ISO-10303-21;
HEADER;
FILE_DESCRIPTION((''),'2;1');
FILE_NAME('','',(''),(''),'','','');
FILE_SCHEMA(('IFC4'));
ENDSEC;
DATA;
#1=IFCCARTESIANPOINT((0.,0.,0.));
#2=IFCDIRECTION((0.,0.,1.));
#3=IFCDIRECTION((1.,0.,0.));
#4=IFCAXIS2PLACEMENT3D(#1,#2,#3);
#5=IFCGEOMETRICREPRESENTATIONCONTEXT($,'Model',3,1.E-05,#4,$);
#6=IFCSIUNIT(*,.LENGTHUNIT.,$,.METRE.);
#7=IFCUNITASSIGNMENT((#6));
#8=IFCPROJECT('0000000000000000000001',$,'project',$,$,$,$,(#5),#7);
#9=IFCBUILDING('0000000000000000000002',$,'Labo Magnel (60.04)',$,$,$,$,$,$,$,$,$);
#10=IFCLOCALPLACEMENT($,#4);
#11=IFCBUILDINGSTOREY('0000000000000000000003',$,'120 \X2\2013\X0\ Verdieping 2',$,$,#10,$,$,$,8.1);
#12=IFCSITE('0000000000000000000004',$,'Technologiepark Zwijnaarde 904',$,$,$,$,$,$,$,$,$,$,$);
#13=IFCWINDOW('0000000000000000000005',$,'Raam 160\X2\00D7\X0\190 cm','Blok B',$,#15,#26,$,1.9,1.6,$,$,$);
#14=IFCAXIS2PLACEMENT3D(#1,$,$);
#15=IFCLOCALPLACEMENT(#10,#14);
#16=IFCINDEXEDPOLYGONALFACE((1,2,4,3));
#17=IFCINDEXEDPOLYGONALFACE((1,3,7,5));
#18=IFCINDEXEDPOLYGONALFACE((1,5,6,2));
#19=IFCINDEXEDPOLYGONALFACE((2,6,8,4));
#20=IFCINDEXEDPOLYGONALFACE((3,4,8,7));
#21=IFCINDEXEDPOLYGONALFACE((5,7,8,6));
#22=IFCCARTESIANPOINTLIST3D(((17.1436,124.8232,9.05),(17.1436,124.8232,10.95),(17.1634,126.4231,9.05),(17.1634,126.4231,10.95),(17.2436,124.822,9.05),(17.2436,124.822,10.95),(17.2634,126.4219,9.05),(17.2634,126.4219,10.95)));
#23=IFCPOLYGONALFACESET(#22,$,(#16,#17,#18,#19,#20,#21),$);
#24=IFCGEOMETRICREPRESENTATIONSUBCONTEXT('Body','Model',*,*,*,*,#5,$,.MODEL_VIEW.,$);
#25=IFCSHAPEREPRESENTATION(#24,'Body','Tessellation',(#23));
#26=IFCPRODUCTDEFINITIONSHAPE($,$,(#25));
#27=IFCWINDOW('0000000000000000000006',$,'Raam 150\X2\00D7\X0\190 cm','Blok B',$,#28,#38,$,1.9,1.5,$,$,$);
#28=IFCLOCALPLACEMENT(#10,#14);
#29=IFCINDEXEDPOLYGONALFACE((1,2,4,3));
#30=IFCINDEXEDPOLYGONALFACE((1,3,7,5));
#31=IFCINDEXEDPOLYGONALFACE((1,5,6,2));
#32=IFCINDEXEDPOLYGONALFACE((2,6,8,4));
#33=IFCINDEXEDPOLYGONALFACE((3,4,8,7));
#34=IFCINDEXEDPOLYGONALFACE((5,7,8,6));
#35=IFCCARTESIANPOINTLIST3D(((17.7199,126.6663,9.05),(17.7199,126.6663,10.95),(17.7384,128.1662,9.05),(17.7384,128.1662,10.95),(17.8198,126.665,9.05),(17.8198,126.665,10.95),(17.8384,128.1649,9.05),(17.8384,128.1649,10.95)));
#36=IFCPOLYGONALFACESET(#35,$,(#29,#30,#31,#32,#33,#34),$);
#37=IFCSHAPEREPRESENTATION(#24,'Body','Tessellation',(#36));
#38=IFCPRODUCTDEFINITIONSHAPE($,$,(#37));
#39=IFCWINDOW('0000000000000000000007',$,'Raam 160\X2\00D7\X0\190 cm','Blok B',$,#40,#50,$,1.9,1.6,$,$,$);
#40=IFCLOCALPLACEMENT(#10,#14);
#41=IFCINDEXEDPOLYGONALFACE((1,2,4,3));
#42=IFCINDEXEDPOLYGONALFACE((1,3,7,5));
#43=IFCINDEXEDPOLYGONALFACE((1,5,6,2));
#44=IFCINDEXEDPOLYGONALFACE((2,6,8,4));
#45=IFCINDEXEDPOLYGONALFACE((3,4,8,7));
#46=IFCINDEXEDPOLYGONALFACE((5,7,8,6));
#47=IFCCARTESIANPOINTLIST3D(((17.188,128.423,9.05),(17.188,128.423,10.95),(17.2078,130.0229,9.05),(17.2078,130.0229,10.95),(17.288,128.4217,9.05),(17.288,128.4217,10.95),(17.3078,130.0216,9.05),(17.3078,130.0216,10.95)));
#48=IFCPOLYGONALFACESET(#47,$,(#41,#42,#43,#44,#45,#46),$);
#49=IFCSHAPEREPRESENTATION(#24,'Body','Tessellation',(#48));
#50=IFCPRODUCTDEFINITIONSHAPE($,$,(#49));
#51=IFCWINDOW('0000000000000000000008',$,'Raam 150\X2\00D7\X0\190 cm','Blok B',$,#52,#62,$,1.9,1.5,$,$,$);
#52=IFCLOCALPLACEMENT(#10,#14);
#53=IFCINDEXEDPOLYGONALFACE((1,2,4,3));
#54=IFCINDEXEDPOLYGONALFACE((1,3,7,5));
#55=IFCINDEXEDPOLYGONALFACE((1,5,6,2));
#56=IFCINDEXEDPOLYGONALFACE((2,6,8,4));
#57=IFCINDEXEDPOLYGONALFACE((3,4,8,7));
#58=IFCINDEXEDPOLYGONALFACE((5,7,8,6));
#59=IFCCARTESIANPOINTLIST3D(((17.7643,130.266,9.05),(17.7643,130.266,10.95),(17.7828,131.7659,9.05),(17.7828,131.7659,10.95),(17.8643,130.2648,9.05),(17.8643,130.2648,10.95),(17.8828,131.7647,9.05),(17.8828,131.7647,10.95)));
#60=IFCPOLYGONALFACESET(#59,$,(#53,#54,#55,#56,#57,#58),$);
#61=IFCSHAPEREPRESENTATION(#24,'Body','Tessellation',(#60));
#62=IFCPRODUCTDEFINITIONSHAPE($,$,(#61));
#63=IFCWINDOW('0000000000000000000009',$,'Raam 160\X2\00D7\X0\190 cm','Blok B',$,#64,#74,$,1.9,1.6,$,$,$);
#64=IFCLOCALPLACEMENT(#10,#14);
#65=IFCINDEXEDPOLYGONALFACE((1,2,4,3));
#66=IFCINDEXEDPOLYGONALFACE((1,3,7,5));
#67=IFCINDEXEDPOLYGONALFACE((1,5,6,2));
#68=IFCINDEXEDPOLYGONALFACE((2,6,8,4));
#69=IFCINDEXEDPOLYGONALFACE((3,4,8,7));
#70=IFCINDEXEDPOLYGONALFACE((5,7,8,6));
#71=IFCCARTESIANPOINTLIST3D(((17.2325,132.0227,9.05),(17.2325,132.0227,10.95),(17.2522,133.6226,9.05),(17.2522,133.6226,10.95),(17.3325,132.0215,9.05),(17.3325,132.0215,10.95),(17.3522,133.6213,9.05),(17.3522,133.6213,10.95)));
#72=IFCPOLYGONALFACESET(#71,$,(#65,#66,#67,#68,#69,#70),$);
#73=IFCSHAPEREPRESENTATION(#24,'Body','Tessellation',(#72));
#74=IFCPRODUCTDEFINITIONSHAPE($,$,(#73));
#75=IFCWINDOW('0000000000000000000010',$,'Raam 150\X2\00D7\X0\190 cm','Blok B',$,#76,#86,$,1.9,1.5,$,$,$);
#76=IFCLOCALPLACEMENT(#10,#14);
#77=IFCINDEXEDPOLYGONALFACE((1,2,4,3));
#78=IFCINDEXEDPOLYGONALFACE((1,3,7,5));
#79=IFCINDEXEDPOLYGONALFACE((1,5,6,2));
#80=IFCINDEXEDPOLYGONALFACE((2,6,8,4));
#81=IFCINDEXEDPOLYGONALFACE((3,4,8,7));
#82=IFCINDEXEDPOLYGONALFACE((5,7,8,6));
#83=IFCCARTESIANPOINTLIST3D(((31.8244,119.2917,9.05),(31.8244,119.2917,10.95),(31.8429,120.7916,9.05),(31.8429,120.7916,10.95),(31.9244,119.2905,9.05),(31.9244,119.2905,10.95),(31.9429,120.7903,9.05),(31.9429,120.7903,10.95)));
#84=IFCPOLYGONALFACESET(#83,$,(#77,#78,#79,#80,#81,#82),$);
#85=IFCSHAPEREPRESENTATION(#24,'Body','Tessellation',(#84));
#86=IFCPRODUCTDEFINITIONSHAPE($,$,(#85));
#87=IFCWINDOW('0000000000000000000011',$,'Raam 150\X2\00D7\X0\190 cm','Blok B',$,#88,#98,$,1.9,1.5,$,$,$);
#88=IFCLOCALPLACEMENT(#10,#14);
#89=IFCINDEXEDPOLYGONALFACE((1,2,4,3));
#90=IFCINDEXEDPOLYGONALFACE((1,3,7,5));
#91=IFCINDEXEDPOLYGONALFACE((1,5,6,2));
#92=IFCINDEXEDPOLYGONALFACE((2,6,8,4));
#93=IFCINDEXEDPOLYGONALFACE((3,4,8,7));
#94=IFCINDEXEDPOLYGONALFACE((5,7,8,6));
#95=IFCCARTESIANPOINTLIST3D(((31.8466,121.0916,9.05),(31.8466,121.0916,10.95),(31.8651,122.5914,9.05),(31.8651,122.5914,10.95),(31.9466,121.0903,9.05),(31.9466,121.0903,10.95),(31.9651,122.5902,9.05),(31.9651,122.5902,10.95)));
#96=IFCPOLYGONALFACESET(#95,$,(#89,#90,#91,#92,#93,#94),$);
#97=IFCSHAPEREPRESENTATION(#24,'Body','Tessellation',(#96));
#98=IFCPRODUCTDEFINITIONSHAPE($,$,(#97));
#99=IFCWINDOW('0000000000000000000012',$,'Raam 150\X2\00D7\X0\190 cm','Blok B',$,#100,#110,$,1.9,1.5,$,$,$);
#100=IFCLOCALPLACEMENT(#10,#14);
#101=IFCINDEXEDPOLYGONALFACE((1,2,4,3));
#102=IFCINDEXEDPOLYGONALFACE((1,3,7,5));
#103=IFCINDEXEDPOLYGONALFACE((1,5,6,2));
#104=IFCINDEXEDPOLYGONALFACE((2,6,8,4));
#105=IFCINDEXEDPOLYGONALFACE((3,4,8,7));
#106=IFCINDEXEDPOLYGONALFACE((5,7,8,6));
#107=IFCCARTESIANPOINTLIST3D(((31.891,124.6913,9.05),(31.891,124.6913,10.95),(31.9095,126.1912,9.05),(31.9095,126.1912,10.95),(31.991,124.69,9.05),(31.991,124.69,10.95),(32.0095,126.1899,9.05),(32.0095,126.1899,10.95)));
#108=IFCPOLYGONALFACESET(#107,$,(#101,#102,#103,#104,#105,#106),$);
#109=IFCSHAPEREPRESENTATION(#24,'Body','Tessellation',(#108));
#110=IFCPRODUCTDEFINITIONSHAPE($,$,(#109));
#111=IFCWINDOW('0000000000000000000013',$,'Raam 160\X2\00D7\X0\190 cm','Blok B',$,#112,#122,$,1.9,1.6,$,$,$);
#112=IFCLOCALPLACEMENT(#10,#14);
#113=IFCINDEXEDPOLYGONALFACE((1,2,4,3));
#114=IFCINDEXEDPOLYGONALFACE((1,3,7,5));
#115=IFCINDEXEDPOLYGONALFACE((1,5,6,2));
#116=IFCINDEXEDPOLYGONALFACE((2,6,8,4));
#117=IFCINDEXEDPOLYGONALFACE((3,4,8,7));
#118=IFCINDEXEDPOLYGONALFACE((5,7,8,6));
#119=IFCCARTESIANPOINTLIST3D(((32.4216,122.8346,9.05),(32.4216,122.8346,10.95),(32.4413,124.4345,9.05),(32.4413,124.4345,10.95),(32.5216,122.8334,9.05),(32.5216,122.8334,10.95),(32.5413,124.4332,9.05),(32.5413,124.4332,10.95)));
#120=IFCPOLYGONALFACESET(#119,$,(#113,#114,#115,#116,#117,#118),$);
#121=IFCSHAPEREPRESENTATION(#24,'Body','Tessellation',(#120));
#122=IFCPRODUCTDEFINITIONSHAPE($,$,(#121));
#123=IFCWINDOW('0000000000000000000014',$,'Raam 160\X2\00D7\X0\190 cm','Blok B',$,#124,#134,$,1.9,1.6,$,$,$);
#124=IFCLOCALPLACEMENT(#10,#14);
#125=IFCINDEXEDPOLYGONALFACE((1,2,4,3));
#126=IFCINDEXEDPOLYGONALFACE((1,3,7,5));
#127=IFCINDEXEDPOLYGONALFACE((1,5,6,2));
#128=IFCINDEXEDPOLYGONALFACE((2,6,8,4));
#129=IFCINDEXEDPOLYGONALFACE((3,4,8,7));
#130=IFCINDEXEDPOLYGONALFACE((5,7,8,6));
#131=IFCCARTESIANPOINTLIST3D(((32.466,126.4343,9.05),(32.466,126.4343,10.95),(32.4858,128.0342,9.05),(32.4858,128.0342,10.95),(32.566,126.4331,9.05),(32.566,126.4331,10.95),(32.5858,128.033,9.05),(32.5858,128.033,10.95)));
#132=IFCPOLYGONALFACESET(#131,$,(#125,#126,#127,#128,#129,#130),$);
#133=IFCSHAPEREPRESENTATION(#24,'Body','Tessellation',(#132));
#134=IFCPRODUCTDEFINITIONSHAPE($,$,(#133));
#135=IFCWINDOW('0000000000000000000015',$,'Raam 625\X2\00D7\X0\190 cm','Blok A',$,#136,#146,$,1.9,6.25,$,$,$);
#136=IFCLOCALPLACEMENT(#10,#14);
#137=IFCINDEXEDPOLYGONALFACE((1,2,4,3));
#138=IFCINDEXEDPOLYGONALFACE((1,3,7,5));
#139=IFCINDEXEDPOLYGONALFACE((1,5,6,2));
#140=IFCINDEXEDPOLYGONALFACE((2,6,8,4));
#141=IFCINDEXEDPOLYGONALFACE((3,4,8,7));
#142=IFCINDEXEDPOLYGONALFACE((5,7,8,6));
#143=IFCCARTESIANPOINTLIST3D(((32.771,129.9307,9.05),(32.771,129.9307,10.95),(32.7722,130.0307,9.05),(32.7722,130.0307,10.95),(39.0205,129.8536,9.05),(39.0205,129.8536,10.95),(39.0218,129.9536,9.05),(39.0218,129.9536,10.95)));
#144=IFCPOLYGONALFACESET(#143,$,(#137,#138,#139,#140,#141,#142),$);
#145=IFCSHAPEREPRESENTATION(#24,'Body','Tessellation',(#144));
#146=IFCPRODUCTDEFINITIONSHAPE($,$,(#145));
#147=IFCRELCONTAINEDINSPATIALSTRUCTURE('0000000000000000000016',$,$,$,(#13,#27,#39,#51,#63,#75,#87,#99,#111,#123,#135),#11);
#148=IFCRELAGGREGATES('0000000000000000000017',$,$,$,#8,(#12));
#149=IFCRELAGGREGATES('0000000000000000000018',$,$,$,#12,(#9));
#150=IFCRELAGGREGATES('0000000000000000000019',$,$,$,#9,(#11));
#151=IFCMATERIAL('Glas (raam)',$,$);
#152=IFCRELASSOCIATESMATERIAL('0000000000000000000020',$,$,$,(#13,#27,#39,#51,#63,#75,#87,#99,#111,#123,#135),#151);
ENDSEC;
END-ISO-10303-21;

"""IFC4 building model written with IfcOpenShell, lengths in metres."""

from ifc_helpers import new_model, si_unit, frame, origin, origin_with_axes, place, context, subcontext, project, spatial, polyline, outline, extrude, material, element, save


model = new_model("IFC4")

# Units and contexts
model_context = context("Model", 3, precision=1e-05, world=origin_with_axes())
body_context = subcontext(model_context, "Body", "Model", "MODEL_VIEW")
ifc_project = project(units=[si_unit("LENGTHUNIT", "METRE")], contexts=[model_context])

# Site, building, storey
site = spatial("IfcSite", under=ifc_project, Name="Technologiepark Zwijnaarde 904")
building = spatial("IfcBuilding", under=site, Name="Labo Magnel (60.04)")
storey_placement = place(None, origin_with_axes())
storey = spatial("IfcBuildingStorey", under=building, at=storey_placement, Name="120 – Verdieping 2", Elevation=8.1)

# Windows
ifc_material_1 = material(Name="Glas (raam)")
window_1_placement = place(storey_placement, frame((17.1936, 124.8226, 9.05), z_axis=(0.0, 0.0, 1.0), x_axis=(0.012338, 0.999924, 0.0)))
element("IfcWindow", 1, at=window_1_placement, inside=storey, material=ifc_material_1, Name="Raam 160×190 cm", Description="Blok B", OverallHeight=1.9, OverallWidth=1.6, context=body_context, shape_type="SweptSolid", body=[
    extrude(outline(polyline([(0.0, -0.05), (1.6, -0.05), (1.6, 0.05), (0.0, 0.05), (0.0, -0.05)])), origin(), (0.0, 0.0, 1.0), 1.9),
])
window_2_placement = place(storey_placement, frame((17.7698, 126.6657, 9.05), z_axis=(0.0, 0.0, 1.0), x_axis=(0.012338, 0.999924, 0.0)))
element("IfcWindow", 2, at=window_2_placement, inside=storey, material=ifc_material_1, Name="Raam 150×190 cm", Description="Blok B", OverallHeight=1.9, OverallWidth=1.5, context=body_context, shape_type="SweptSolid", body=[
    extrude(outline(polyline([(0.0, -0.05), (1.5, -0.05), (1.5, 0.05), (0.0, 0.05), (0.0, -0.05)])), origin(), (0.0, 0.0, 1.0), 1.9),
])
window_3_placement = place(storey_placement, frame((17.2578, 130.0222, 9.05), z_axis=(0.0, 0.0, 1.0), x_axis=(-0.012338, -0.999924, 0.0)))
element("IfcWindow", 3, at=window_3_placement, inside=storey, material=ifc_material_1, Name="Raam 160×190 cm", Description="Blok B", OverallHeight=1.9, OverallWidth=1.6, context=body_context, shape_type="SweptSolid", body=[
    extrude(outline(polyline([(0.0, -0.05), (1.6, -0.05), (1.6, 0.05), (0.0, 0.05), (0.0, -0.05)])), origin(), (0.0, 0.0, 1.0), 1.9),
])
window_4_placement = place(storey_placement, frame((17.8328, 131.7653, 9.05), z_axis=(0.0, 0.0, 1.0), x_axis=(-0.012338, -0.999924, 0.0)))
element("IfcWindow", 4, at=window_4_placement, inside=storey, material=ifc_material_1, Name="Raam 150×190 cm", Description="Blok B", OverallHeight=1.9, OverallWidth=1.5, context=body_context, shape_type="SweptSolid", body=[
    extrude(outline(polyline([(0.0, -0.05), (1.5, -0.05), (1.5, 0.05), (0.0, 0.05), (0.0, -0.05)])), origin(), (0.0, 0.0, 1.0), 1.9),
])
window_5_placement = place(storey_placement, frame((17.3022, 133.622, 9.05), z_axis=(0.0, 0.0, 1.0), x_axis=(-0.012338, -0.999924, 0.0)))
element("IfcWindow", 5, at=window_5_placement, inside=storey, material=ifc_material_1, Name="Raam 160×190 cm", Description="Blok B", OverallHeight=1.9, OverallWidth=1.6, context=body_context, shape_type="SweptSolid", body=[
    extrude(outline(polyline([(0.0, -0.05), (1.6, -0.05), (1.6, 0.05), (0.0, 0.05), (0.0, -0.05)])), origin(), (0.0, 0.0, 1.0), 1.9),
])
window_6_placement = place(storey_placement, frame((31.8744, 119.2911, 9.05), z_axis=(0.0, 0.0, 1.0), x_axis=(0.012338, 0.999924, 0.0)))
element("IfcWindow", 6, at=window_6_placement, inside=storey, material=ifc_material_1, Name="Raam 150×190 cm", Description="Blok B", OverallHeight=1.9, OverallWidth=1.5, context=body_context, shape_type="SweptSolid", body=[
    extrude(outline(polyline([(0.0, -0.05), (1.5, -0.05), (1.5, 0.05), (0.0, 0.05), (0.0, -0.05)])), origin(), (0.0, 0.0, 1.0), 1.9),
])
window_7_placement = place(storey_placement, frame((31.8966, 121.0909, 9.05), z_axis=(0.0, 0.0, 1.0), x_axis=(0.012338, 0.999924, 0.0)))
element("IfcWindow", 7, at=window_7_placement, inside=storey, material=ifc_material_1, Name="Raam 150×190 cm", Description="Blok B", OverallHeight=1.9, OverallWidth=1.5, context=body_context, shape_type="SweptSolid", body=[
    extrude(outline(polyline([(0.0, -0.05), (1.5, -0.05), (1.5, 0.05), (0.0, 0.05), (0.0, -0.05)])), origin(), (0.0, 0.0, 1.0), 1.9),
])
window_8_placement = place(storey_placement, frame((31.941, 124.6907, 9.05), z_axis=(0.0, 0.0, 1.0), x_axis=(0.012338, 0.999924, 0.0)))
element("IfcWindow", 8, at=window_8_placement, inside=storey, material=ifc_material_1, Name="Raam 150×190 cm", Description="Blok B", OverallHeight=1.9, OverallWidth=1.5, context=body_context, shape_type="SweptSolid", body=[
    extrude(outline(polyline([(0.0, -0.05), (1.5, -0.05), (1.5, 0.05), (0.0, 0.05), (0.0, -0.05)])), origin(), (0.0, 0.0, 1.0), 1.9),
])
window_9_placement = place(storey_placement, frame((32.4716, 122.834, 9.05), z_axis=(0.0, 0.0, 1.0), x_axis=(0.012338, 0.999924, 0.0)))
element("IfcWindow", 9, at=window_9_placement, inside=storey, material=ifc_material_1, Name="Raam 160×190 cm", Description="Blok B", OverallHeight=1.9, OverallWidth=1.6, context=body_context, shape_type="SweptSolid", body=[
    extrude(outline(polyline([(0.0, -0.05), (1.6, -0.05), (1.6, 0.05), (0.0, 0.05), (0.0, -0.05)])), origin(), (0.0, 0.0, 1.0), 1.9),
])
window_10_placement = place(storey_placement, frame((32.516, 126.4337, 9.05), z_axis=(0.0, 0.0, 1.0), x_axis=(0.012338, 0.999924, 0.0)))
element("IfcWindow", 10, at=window_10_placement, inside=storey, material=ifc_material_1, Name="Raam 160×190 cm", Description="Blok B", OverallHeight=1.9, OverallWidth=1.6, context=body_context, shape_type="SweptSolid", body=[
    extrude(outline(polyline([(0.0, -0.05), (1.6, -0.05), (1.6, 0.05), (0.0, 0.05), (0.0, -0.05)])), origin(), (0.0, 0.0, 1.0), 1.9),
])
window_11_placement = place(storey_placement, frame((39.0212, 129.9036, 9.05), z_axis=(0.0, 0.0, 1.0), x_axis=(-0.999924, 0.012338, 0.0)))
element("IfcWindow", 11, at=window_11_placement, inside=storey, material=ifc_material_1, Name="Raam 625×190 cm", Description="Blok A", OverallHeight=1.9, OverallWidth=6.25, context=body_context, shape_type="SweptSolid", body=[
    extrude(outline(polyline([(0.0, -0.05), (6.25, -0.05), (6.25, 0.05), (0.0, 0.05), (0.0, -0.05)])), origin(), (0.0, 0.0, 1.0), 1.9),
])

save(model, "model.ifc")
